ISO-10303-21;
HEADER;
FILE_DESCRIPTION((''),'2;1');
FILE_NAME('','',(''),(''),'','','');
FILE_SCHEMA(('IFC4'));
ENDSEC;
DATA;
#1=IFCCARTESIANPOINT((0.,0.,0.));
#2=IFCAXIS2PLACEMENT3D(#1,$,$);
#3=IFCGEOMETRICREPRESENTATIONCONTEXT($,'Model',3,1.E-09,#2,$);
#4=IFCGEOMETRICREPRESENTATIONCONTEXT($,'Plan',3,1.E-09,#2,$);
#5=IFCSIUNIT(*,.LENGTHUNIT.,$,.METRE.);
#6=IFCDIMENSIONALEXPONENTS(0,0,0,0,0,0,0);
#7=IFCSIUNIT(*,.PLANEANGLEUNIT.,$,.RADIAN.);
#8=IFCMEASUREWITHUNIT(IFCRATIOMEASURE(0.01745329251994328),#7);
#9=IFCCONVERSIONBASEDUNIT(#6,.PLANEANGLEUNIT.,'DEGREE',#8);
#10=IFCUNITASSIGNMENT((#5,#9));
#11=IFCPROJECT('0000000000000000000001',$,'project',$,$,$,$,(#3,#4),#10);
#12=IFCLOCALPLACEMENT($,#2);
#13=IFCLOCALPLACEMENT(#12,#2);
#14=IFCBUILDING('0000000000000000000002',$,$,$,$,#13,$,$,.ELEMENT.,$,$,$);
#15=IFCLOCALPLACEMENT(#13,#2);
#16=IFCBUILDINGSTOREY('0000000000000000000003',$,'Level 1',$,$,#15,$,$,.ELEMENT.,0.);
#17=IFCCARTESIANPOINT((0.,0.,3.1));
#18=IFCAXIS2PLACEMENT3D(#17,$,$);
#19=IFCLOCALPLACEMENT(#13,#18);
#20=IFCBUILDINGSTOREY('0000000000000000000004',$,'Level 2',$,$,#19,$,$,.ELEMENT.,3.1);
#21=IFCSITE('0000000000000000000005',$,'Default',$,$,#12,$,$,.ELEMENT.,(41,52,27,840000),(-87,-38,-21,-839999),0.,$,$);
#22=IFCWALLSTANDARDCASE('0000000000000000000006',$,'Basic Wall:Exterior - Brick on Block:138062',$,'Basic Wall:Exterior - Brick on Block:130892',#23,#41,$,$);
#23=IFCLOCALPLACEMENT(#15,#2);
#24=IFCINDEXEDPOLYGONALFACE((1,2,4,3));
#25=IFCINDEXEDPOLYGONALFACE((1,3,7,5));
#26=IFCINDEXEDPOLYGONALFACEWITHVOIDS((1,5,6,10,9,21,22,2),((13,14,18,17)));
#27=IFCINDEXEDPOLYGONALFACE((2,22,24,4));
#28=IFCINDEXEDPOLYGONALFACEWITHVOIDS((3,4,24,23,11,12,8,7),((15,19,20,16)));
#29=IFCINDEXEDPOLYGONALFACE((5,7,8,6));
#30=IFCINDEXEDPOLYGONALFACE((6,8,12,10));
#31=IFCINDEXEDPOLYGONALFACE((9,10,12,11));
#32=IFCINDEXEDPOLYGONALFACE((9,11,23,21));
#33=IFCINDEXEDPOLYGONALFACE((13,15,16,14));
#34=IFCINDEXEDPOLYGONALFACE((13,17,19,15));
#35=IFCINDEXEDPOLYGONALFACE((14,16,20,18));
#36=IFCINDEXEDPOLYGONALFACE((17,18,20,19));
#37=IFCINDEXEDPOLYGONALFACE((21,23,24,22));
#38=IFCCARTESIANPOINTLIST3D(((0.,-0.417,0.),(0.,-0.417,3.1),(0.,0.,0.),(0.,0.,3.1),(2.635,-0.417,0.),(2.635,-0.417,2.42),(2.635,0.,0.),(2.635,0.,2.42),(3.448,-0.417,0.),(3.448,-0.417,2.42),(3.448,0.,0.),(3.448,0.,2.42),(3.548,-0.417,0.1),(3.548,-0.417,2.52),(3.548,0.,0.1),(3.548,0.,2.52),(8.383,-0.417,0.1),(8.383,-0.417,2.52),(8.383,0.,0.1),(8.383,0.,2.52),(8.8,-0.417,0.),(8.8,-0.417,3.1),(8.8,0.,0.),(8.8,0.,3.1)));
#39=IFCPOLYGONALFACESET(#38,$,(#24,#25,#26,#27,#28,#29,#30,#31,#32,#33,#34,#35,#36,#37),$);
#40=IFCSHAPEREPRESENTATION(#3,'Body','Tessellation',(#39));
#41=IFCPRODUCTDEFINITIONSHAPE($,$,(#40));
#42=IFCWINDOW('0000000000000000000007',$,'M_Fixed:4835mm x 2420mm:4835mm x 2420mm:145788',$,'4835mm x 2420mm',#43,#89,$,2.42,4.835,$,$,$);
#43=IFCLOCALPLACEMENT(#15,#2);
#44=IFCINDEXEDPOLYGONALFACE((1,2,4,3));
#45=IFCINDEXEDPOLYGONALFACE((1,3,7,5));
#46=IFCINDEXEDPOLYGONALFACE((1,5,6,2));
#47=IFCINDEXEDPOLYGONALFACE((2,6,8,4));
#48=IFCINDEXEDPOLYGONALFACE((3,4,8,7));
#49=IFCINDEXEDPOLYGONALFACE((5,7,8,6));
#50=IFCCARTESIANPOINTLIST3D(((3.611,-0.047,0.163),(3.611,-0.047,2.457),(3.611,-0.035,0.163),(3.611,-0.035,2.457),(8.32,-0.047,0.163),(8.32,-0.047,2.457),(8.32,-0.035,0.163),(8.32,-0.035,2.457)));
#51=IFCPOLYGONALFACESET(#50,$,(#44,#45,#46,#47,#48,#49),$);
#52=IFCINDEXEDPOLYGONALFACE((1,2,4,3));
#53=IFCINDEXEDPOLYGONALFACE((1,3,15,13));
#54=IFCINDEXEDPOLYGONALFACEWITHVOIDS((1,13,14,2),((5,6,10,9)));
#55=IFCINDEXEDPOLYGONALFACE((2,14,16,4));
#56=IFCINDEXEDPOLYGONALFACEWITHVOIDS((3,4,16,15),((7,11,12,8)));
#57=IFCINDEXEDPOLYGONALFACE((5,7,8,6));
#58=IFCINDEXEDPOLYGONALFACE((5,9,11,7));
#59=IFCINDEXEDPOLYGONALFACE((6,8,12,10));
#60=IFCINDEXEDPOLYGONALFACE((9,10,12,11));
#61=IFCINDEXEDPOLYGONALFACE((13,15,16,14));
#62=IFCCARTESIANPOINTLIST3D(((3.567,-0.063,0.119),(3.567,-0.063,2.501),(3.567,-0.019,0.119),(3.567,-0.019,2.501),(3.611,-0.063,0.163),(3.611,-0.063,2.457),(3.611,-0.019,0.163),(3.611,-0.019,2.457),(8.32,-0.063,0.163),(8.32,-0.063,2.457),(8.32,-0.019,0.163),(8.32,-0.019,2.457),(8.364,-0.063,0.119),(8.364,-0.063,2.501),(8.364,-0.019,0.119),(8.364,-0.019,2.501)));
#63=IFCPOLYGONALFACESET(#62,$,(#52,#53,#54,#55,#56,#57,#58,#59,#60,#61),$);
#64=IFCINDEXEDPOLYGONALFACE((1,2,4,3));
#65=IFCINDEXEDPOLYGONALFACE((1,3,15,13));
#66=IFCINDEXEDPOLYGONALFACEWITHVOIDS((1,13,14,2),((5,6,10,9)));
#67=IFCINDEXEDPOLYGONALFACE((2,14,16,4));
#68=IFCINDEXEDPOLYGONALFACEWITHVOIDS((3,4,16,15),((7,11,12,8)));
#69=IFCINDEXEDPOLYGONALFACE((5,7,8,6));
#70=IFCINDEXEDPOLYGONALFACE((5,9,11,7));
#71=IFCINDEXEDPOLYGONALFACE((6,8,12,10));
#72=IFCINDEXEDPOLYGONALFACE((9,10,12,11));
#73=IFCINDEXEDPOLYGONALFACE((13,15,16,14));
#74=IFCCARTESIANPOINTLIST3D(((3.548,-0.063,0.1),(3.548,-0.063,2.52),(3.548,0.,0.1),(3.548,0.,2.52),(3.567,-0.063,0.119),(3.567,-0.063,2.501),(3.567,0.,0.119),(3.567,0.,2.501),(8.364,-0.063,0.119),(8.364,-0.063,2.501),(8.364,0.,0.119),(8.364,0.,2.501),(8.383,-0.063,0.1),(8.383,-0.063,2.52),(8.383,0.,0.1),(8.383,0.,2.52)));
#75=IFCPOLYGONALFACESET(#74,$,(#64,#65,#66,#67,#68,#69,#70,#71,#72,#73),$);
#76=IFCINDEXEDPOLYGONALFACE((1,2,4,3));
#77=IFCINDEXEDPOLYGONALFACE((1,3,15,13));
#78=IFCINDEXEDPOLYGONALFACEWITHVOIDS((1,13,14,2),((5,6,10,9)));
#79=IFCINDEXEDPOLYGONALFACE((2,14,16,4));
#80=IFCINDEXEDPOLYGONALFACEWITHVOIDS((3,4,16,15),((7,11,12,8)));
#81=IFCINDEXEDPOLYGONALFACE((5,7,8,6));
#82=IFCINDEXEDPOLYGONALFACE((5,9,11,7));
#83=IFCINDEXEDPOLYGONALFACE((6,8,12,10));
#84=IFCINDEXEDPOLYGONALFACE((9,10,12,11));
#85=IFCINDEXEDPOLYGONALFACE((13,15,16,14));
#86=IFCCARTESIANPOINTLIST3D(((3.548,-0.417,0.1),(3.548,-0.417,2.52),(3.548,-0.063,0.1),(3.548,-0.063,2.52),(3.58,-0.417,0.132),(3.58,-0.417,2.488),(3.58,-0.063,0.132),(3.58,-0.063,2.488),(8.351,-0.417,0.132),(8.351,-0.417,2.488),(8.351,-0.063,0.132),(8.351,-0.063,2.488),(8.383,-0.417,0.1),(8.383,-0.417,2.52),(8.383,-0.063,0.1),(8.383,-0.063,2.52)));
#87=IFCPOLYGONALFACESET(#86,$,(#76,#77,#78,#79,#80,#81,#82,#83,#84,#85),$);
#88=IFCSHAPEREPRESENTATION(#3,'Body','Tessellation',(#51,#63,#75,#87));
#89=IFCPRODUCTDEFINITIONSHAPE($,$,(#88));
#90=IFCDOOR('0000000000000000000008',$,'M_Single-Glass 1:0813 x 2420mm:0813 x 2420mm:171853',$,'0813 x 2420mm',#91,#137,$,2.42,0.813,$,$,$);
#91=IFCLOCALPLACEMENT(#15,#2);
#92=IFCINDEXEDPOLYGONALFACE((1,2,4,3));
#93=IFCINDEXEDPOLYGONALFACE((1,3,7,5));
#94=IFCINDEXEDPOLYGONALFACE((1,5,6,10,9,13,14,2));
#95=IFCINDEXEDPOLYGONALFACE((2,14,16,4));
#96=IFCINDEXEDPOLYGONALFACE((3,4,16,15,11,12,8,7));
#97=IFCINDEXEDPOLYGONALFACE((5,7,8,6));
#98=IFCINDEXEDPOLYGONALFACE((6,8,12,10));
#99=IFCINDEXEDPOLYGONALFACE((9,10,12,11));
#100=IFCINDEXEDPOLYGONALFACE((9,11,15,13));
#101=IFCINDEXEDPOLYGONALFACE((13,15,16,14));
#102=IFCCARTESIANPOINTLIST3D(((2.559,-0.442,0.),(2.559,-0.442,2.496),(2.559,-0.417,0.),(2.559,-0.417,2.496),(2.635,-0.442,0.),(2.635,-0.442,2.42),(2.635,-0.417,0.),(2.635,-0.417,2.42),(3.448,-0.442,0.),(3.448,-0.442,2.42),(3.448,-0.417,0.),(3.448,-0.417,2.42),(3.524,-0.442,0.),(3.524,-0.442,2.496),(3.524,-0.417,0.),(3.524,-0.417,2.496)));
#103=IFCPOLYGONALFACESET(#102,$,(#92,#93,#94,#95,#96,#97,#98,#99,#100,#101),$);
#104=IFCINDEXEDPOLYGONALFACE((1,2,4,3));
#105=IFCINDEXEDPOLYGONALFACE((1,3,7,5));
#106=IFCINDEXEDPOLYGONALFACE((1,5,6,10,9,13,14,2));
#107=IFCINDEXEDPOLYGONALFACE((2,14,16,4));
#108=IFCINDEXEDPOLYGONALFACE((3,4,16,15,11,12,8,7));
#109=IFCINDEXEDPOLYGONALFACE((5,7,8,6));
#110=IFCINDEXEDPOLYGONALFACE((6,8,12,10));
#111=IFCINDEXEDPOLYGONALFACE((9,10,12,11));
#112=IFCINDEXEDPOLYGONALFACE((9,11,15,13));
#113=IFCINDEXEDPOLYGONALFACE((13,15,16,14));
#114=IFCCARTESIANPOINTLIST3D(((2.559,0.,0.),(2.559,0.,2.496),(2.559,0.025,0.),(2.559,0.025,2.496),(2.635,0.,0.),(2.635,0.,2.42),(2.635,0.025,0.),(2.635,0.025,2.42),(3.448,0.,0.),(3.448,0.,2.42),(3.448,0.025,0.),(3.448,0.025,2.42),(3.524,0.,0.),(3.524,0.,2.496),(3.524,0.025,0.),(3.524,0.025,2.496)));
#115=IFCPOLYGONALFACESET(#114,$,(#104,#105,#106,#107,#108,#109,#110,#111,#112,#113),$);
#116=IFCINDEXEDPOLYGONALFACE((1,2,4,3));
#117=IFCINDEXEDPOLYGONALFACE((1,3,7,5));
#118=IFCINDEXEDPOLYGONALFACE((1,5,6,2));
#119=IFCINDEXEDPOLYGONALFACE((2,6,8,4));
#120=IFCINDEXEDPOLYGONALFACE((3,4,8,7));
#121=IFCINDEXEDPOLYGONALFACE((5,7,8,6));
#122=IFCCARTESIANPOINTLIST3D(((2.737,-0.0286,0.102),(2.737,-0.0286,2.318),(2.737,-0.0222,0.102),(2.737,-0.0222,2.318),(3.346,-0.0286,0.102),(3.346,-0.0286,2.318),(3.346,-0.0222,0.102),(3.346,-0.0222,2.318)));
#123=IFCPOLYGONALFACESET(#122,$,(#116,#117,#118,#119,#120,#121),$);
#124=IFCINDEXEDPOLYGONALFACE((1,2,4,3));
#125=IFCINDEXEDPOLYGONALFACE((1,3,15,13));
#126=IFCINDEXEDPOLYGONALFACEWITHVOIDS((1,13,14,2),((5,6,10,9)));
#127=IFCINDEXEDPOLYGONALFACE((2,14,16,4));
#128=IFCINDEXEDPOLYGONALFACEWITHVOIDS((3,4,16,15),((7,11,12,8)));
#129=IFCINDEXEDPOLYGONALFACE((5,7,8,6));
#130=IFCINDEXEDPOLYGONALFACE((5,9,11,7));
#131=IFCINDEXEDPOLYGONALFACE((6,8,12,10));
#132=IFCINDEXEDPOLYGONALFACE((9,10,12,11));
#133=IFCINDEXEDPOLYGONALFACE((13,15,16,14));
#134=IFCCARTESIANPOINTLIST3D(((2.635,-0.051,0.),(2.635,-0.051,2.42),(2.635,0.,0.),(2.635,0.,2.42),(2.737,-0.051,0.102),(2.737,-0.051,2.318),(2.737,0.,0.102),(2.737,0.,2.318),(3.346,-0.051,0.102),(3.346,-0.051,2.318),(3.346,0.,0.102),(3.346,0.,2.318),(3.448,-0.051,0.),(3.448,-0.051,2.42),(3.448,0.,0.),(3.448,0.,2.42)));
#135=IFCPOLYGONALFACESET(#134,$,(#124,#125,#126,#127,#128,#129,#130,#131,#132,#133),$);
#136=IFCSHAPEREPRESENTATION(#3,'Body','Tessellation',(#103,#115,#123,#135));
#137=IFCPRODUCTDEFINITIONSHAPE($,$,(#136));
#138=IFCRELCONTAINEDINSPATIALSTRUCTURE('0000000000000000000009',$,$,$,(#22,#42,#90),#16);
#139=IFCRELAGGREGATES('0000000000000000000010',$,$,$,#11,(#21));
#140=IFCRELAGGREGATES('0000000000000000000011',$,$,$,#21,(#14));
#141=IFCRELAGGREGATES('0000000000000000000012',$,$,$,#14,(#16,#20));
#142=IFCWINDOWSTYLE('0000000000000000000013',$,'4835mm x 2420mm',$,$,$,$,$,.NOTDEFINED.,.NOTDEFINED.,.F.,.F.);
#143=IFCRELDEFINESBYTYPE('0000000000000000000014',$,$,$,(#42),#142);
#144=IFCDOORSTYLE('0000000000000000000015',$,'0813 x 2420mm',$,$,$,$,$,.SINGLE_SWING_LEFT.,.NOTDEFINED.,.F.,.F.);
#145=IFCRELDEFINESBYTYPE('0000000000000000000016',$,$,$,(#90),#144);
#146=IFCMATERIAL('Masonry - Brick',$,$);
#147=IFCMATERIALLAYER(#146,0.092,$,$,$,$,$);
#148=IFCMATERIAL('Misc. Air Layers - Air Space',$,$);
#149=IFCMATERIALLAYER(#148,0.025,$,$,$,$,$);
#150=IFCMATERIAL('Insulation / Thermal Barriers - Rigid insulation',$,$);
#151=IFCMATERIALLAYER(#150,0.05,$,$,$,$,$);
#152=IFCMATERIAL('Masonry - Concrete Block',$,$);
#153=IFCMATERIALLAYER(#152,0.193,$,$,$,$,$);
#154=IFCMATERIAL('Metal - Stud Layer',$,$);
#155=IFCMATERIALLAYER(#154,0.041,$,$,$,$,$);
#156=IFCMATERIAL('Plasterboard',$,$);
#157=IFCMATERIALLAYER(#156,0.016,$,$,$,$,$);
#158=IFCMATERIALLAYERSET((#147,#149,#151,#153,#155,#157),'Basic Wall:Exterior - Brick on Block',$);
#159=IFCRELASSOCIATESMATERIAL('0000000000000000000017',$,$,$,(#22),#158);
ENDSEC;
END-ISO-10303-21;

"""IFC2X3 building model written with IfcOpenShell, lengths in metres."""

from ifc_helpers import new_model, entity, si_unit, converted_unit, frame, frame_2d, origin, origin_2d_with_axis, place, context, project, spatial, polyline, rectangle, outline, extrude, source, transform, mapped, material, layer, layer_set, layer_usage, type_object, type_shapes, element, fill, save


model = new_model("IFC2X3")

# Units and contexts
model_context = context("Model", 3, precision=1e-09, world=origin())
plan_context = context("Plan", 3, precision=1e-09, world=origin())
ifc_project = project(units=[si_unit("LENGTHUNIT", "METRE"), converted_unit("PLANEANGLEUNIT", "DEGREE", entity("IfcRatioMeasure", 0.01745329251994328), si_unit("PLANEANGLEUNIT", "RADIAN"), dimensions=[0, 0, 0, 0, 0, 0, 0])], contexts=[model_context, plan_context])

# Site, building, storey
site_placement = place(None, origin())
site = spatial("IfcSite", under=ifc_project, at=site_placement, Name="Default", CompositionType="ELEMENT", RefLatitude=(41, 52, 27, 840000), RefLongitude=(-87, -38, -21, -839999), RefElevation=0.0)
building_placement = place(site_placement, origin())
building = spatial("IfcBuilding", under=site, at=building_placement, CompositionType="ELEMENT")
storey_1_placement = place(building_placement, origin())
storey_1 = spatial("IfcBuildingStorey", under=building, at=storey_1_placement, Name="Level 1", CompositionType="ELEMENT", Elevation=0.0)

# Wall, openings, window, door
ifc_material_1 = material(Name="Masonry - Brick")
ifc_layer_1 = layer(ifc_material_1, 0.092)
ifc_material_2 = material(Name="Misc. Air Layers - Air Space")
ifc_layer_2 = layer(ifc_material_2, 0.025)
ifc_material_3 = material(Name="Insulation / Thermal Barriers - Rigid insulation")
ifc_layer_3 = layer(ifc_material_3, 0.05)
ifc_material_4 = material(Name="Masonry - Concrete Block")
ifc_layer_4 = layer(ifc_material_4, 0.193)
ifc_material_5 = material(Name="Metal - Stud Layer")
ifc_layer_5 = layer(ifc_material_5, 0.041)
ifc_material_6 = material(Name="Plasterboard")
ifc_layer_6 = layer(ifc_material_6, 0.016)
ifc_layer_set_1 = layer_set([ifc_layer_1, ifc_layer_2, ifc_layer_3, ifc_layer_4, ifc_layer_5, ifc_layer_6], Name="Basic Wall:Exterior - Brick on Block")
ifc_layer_usage_1 = layer_usage(ifc_layer_set_1, "AXIS2", "NEGATIVE", 0.2085)
wall_1_placement = place(storey_1_placement, frame((0.0, -0.2085, 0.0)))
wall_1 = element("IfcWallStandardCase", 1, at=wall_1_placement, inside=storey_1, material=ifc_layer_usage_1, Name="Basic Wall:Exterior - Brick on Block:138062", ObjectType="Basic Wall:Exterior - Brick on Block:130892", context=model_context, shape_type="SweptSolid", body=[
    extrude(rectangle(XDim=8.8, YDim=0.417, at=frame_2d((4.4, 0.0), x_axis=(-1.0, 0.0))), origin(), (0.0, 0.0, 1.0), 3.1),
])
opening_1_placement = place(wall_1_placement, frame((3.548, -0.2085, 0.1)))
opening_1 = element("IfcOpeningElement", 2, at=opening_1_placement, cuts=wall_1, ObjectType="Opening", context=model_context, shape_type="SweptSolid", body=[
    extrude(rectangle(XDim=2.42, YDim=4.835, at=frame_2d((1.21, 2.4175), x_axis=(1.0, 0.0))), frame((0.0, 0.0, 0.0), z_axis=(0.0, 1.0, 0.0), x_axis=(0.0, 0.0, 1.0)), (0.0, 0.0, 1.0), 0.417),
])
opening_2_placement = place(wall_1_placement, frame((2.635, -0.2085, 0.0)))
opening_2 = element("IfcOpeningElement", 3, at=opening_2_placement, cuts=wall_1, ObjectType="Opening", context=model_context, shape_type="SweptSolid", body=[
    extrude(rectangle(XDim=0.813, YDim=2.42, at=frame_2d((1.21, 0.4065), x_axis=(0.0, -1.0))), frame((0.0, 0.0, 0.0), z_axis=(0.0, 1.0, 0.0), x_axis=(0.0, 0.0, 1.0)), (0.0, 0.0, 1.0), 0.417),
])
window_style_1 = type_object("IfcWindowStyle", Name="4835mm x 2420mm", ConstructionType="NOTDEFINED", OperationType="NOTDEFINED", ParameterTakesPrecedence=False, Sizeable=False)
shared_shape_1 = source(origin(), model_context, "Body", "SweptSolid", [
    extrude(rectangle(XDim=0.012, YDim=4.709, at=origin_2d_with_axis()), frame((2.4175, 0.376, 0.063), z_axis=(0.0, 0.0, 1.0), x_axis=(0.0, -1.0, 0.0)), (0.0, 0.0, 1.0), 2.294),
    extrude(outline(polyline([(-2.3985, -1.191), (2.3985, -1.191), (2.3985, 1.191), (-2.3985, 1.191), (-2.3985, -1.191)]), holes=[polyline([(-2.3545, -1.147), (-2.3545, 1.147), (2.3545, 1.147), (2.3545, -1.147), (-2.3545, -1.147)])]), frame((2.4175, 0.354, 1.21), z_axis=(0.0, 1.0, 0.0), x_axis=(1.0, 0.0, 0.0)), (0.0, 0.0, 1.0), 0.044),
    extrude(outline(polyline([(-2.4175, -1.21), (2.4175, -1.21), (2.4175, 1.21), (-2.4175, 1.21), (-2.4175, -1.21)]), holes=[polyline([(-2.3985, -1.191), (-2.3985, 1.191), (2.3985, 1.191), (2.3985, -1.191), (-2.3985, -1.191)])]), frame((2.4175, 0.354, 1.21), z_axis=(0.0, 1.0, 0.0), x_axis=(1.0, 0.0, 0.0)), (0.0, 0.0, 1.0), 0.063),
    extrude(outline(polyline([(-2.4175, -1.21), (2.4175, -1.21), (2.4175, 1.21), (-2.4175, 1.21), (-2.4175, -1.21)]), holes=[polyline([(-2.3855, -1.178), (-2.3855, 1.178), (2.3855, 1.178), (2.3855, -1.178), (-2.3855, -1.178)])]), frame((2.4175, 0.0, 1.21), z_axis=(0.0, 1.0, 0.0), x_axis=(1.0, 0.0, 0.0)), (0.0, 0.0, 1.0), 0.354),
])
type_shapes(window_style_1, [shared_shape_1])
window_1_placement = place(opening_1_placement, origin())
window_1 = element("IfcWindow", 4, at=window_1_placement, inside=storey_1, type_object=window_style_1, Name="M_Fixed:4835mm x 2420mm:4835mm x 2420mm:145788", ObjectType="4835mm x 2420mm", OverallHeight=2.42, OverallWidth=4.835, context=model_context, shape_type="MappedRepresentation", body=[
    mapped(shared_shape_1, transform((0.0, 0.0, 0.0), scale=1.0)),
])
fill(opening_1, window_1)
door_style_1 = type_object("IfcDoorStyle", Name="0813 x 2420mm", ConstructionType="NOTDEFINED", OperationType="SINGLE_SWING_LEFT", ParameterTakesPrecedence=False, Sizeable=False)
shared_shape_2 = source(origin(), model_context, "Body", "SweptSolid", [
    extrude(outline(polyline([(-0.4065, -1.191), (-0.4065, 1.229), (-0.4825, 1.229), (-0.4825, -1.267), (0.4825, -1.267), (0.4825, 1.229), (0.4065, 1.229), (0.4065, -1.191), (-0.4065, -1.191)])), frame((0.4065, 0.0, 1.229), z_axis=(0.0, 1.0, 0.0), x_axis=(1.0, 0.0, 0.0)), (0.0, 0.0, -1.0), 0.025),
    extrude(outline(polyline([(-0.4065, -1.191), (-0.4065, 1.229), (-0.4825, 1.229), (-0.4825, -1.267), (0.4825, -1.267), (0.4825, 1.229), (0.4065, 1.229), (0.4065, -1.191), (-0.4065, -1.191)])), frame((0.4065, 0.442, 1.229), z_axis=(0.0, 1.0, 0.0), x_axis=(1.0, 0.0, 0.0)), (0.0, 0.0, -1.0), 0.025),
    extrude(rectangle(XDim=0.609, YDim=0.0064, at=origin_2d_with_axis()), frame((0.4065, 0.3916, 0.102)), (0.0, 0.0, 1.0), 2.216),
    extrude(outline(polyline([(-1.21, -0.4065), (1.21, -0.4065), (1.21, 0.4065), (-1.21, 0.4065), (-1.21, -0.4065)]), holes=[polyline([(-1.108, 0.3045), (1.108, 0.3045), (1.108, -0.3045), (-1.108, -0.3045), (-1.108, 0.3045)])]), frame((0.4065, 0.417, 1.21), z_axis=(0.0, -1.0, 0.0), x_axis=(0.0, 0.0, -1.0)), (0.0, 0.0, 1.0), 0.051),
])
type_shapes(door_style_1, [shared_shape_2])
door_1_placement = place(opening_2_placement, origin())
door_1 = element("IfcDoor", 5, at=door_1_placement, inside=storey_1, type_object=door_style_1, Name="M_Single-Glass 1:0813 x 2420mm:0813 x 2420mm:171853", ObjectType="0813 x 2420mm", OverallHeight=2.42, OverallWidth=0.813, context=model_context, shape_type="MappedRepresentation", body=[
    mapped(shared_shape_2, transform((0.0, 0.0, 0.0), scale=1.0)),
])
fill(opening_2, door_1)

# Shared definitions
storey_2_placement = place(building_placement, frame((0.0, 0.0, 3.1)))
storey_2 = spatial("IfcBuildingStorey", under=building, at=storey_2_placement, Name="Level 2", CompositionType="ELEMENT", Elevation=3.1)

save(model, "model.ifc")
